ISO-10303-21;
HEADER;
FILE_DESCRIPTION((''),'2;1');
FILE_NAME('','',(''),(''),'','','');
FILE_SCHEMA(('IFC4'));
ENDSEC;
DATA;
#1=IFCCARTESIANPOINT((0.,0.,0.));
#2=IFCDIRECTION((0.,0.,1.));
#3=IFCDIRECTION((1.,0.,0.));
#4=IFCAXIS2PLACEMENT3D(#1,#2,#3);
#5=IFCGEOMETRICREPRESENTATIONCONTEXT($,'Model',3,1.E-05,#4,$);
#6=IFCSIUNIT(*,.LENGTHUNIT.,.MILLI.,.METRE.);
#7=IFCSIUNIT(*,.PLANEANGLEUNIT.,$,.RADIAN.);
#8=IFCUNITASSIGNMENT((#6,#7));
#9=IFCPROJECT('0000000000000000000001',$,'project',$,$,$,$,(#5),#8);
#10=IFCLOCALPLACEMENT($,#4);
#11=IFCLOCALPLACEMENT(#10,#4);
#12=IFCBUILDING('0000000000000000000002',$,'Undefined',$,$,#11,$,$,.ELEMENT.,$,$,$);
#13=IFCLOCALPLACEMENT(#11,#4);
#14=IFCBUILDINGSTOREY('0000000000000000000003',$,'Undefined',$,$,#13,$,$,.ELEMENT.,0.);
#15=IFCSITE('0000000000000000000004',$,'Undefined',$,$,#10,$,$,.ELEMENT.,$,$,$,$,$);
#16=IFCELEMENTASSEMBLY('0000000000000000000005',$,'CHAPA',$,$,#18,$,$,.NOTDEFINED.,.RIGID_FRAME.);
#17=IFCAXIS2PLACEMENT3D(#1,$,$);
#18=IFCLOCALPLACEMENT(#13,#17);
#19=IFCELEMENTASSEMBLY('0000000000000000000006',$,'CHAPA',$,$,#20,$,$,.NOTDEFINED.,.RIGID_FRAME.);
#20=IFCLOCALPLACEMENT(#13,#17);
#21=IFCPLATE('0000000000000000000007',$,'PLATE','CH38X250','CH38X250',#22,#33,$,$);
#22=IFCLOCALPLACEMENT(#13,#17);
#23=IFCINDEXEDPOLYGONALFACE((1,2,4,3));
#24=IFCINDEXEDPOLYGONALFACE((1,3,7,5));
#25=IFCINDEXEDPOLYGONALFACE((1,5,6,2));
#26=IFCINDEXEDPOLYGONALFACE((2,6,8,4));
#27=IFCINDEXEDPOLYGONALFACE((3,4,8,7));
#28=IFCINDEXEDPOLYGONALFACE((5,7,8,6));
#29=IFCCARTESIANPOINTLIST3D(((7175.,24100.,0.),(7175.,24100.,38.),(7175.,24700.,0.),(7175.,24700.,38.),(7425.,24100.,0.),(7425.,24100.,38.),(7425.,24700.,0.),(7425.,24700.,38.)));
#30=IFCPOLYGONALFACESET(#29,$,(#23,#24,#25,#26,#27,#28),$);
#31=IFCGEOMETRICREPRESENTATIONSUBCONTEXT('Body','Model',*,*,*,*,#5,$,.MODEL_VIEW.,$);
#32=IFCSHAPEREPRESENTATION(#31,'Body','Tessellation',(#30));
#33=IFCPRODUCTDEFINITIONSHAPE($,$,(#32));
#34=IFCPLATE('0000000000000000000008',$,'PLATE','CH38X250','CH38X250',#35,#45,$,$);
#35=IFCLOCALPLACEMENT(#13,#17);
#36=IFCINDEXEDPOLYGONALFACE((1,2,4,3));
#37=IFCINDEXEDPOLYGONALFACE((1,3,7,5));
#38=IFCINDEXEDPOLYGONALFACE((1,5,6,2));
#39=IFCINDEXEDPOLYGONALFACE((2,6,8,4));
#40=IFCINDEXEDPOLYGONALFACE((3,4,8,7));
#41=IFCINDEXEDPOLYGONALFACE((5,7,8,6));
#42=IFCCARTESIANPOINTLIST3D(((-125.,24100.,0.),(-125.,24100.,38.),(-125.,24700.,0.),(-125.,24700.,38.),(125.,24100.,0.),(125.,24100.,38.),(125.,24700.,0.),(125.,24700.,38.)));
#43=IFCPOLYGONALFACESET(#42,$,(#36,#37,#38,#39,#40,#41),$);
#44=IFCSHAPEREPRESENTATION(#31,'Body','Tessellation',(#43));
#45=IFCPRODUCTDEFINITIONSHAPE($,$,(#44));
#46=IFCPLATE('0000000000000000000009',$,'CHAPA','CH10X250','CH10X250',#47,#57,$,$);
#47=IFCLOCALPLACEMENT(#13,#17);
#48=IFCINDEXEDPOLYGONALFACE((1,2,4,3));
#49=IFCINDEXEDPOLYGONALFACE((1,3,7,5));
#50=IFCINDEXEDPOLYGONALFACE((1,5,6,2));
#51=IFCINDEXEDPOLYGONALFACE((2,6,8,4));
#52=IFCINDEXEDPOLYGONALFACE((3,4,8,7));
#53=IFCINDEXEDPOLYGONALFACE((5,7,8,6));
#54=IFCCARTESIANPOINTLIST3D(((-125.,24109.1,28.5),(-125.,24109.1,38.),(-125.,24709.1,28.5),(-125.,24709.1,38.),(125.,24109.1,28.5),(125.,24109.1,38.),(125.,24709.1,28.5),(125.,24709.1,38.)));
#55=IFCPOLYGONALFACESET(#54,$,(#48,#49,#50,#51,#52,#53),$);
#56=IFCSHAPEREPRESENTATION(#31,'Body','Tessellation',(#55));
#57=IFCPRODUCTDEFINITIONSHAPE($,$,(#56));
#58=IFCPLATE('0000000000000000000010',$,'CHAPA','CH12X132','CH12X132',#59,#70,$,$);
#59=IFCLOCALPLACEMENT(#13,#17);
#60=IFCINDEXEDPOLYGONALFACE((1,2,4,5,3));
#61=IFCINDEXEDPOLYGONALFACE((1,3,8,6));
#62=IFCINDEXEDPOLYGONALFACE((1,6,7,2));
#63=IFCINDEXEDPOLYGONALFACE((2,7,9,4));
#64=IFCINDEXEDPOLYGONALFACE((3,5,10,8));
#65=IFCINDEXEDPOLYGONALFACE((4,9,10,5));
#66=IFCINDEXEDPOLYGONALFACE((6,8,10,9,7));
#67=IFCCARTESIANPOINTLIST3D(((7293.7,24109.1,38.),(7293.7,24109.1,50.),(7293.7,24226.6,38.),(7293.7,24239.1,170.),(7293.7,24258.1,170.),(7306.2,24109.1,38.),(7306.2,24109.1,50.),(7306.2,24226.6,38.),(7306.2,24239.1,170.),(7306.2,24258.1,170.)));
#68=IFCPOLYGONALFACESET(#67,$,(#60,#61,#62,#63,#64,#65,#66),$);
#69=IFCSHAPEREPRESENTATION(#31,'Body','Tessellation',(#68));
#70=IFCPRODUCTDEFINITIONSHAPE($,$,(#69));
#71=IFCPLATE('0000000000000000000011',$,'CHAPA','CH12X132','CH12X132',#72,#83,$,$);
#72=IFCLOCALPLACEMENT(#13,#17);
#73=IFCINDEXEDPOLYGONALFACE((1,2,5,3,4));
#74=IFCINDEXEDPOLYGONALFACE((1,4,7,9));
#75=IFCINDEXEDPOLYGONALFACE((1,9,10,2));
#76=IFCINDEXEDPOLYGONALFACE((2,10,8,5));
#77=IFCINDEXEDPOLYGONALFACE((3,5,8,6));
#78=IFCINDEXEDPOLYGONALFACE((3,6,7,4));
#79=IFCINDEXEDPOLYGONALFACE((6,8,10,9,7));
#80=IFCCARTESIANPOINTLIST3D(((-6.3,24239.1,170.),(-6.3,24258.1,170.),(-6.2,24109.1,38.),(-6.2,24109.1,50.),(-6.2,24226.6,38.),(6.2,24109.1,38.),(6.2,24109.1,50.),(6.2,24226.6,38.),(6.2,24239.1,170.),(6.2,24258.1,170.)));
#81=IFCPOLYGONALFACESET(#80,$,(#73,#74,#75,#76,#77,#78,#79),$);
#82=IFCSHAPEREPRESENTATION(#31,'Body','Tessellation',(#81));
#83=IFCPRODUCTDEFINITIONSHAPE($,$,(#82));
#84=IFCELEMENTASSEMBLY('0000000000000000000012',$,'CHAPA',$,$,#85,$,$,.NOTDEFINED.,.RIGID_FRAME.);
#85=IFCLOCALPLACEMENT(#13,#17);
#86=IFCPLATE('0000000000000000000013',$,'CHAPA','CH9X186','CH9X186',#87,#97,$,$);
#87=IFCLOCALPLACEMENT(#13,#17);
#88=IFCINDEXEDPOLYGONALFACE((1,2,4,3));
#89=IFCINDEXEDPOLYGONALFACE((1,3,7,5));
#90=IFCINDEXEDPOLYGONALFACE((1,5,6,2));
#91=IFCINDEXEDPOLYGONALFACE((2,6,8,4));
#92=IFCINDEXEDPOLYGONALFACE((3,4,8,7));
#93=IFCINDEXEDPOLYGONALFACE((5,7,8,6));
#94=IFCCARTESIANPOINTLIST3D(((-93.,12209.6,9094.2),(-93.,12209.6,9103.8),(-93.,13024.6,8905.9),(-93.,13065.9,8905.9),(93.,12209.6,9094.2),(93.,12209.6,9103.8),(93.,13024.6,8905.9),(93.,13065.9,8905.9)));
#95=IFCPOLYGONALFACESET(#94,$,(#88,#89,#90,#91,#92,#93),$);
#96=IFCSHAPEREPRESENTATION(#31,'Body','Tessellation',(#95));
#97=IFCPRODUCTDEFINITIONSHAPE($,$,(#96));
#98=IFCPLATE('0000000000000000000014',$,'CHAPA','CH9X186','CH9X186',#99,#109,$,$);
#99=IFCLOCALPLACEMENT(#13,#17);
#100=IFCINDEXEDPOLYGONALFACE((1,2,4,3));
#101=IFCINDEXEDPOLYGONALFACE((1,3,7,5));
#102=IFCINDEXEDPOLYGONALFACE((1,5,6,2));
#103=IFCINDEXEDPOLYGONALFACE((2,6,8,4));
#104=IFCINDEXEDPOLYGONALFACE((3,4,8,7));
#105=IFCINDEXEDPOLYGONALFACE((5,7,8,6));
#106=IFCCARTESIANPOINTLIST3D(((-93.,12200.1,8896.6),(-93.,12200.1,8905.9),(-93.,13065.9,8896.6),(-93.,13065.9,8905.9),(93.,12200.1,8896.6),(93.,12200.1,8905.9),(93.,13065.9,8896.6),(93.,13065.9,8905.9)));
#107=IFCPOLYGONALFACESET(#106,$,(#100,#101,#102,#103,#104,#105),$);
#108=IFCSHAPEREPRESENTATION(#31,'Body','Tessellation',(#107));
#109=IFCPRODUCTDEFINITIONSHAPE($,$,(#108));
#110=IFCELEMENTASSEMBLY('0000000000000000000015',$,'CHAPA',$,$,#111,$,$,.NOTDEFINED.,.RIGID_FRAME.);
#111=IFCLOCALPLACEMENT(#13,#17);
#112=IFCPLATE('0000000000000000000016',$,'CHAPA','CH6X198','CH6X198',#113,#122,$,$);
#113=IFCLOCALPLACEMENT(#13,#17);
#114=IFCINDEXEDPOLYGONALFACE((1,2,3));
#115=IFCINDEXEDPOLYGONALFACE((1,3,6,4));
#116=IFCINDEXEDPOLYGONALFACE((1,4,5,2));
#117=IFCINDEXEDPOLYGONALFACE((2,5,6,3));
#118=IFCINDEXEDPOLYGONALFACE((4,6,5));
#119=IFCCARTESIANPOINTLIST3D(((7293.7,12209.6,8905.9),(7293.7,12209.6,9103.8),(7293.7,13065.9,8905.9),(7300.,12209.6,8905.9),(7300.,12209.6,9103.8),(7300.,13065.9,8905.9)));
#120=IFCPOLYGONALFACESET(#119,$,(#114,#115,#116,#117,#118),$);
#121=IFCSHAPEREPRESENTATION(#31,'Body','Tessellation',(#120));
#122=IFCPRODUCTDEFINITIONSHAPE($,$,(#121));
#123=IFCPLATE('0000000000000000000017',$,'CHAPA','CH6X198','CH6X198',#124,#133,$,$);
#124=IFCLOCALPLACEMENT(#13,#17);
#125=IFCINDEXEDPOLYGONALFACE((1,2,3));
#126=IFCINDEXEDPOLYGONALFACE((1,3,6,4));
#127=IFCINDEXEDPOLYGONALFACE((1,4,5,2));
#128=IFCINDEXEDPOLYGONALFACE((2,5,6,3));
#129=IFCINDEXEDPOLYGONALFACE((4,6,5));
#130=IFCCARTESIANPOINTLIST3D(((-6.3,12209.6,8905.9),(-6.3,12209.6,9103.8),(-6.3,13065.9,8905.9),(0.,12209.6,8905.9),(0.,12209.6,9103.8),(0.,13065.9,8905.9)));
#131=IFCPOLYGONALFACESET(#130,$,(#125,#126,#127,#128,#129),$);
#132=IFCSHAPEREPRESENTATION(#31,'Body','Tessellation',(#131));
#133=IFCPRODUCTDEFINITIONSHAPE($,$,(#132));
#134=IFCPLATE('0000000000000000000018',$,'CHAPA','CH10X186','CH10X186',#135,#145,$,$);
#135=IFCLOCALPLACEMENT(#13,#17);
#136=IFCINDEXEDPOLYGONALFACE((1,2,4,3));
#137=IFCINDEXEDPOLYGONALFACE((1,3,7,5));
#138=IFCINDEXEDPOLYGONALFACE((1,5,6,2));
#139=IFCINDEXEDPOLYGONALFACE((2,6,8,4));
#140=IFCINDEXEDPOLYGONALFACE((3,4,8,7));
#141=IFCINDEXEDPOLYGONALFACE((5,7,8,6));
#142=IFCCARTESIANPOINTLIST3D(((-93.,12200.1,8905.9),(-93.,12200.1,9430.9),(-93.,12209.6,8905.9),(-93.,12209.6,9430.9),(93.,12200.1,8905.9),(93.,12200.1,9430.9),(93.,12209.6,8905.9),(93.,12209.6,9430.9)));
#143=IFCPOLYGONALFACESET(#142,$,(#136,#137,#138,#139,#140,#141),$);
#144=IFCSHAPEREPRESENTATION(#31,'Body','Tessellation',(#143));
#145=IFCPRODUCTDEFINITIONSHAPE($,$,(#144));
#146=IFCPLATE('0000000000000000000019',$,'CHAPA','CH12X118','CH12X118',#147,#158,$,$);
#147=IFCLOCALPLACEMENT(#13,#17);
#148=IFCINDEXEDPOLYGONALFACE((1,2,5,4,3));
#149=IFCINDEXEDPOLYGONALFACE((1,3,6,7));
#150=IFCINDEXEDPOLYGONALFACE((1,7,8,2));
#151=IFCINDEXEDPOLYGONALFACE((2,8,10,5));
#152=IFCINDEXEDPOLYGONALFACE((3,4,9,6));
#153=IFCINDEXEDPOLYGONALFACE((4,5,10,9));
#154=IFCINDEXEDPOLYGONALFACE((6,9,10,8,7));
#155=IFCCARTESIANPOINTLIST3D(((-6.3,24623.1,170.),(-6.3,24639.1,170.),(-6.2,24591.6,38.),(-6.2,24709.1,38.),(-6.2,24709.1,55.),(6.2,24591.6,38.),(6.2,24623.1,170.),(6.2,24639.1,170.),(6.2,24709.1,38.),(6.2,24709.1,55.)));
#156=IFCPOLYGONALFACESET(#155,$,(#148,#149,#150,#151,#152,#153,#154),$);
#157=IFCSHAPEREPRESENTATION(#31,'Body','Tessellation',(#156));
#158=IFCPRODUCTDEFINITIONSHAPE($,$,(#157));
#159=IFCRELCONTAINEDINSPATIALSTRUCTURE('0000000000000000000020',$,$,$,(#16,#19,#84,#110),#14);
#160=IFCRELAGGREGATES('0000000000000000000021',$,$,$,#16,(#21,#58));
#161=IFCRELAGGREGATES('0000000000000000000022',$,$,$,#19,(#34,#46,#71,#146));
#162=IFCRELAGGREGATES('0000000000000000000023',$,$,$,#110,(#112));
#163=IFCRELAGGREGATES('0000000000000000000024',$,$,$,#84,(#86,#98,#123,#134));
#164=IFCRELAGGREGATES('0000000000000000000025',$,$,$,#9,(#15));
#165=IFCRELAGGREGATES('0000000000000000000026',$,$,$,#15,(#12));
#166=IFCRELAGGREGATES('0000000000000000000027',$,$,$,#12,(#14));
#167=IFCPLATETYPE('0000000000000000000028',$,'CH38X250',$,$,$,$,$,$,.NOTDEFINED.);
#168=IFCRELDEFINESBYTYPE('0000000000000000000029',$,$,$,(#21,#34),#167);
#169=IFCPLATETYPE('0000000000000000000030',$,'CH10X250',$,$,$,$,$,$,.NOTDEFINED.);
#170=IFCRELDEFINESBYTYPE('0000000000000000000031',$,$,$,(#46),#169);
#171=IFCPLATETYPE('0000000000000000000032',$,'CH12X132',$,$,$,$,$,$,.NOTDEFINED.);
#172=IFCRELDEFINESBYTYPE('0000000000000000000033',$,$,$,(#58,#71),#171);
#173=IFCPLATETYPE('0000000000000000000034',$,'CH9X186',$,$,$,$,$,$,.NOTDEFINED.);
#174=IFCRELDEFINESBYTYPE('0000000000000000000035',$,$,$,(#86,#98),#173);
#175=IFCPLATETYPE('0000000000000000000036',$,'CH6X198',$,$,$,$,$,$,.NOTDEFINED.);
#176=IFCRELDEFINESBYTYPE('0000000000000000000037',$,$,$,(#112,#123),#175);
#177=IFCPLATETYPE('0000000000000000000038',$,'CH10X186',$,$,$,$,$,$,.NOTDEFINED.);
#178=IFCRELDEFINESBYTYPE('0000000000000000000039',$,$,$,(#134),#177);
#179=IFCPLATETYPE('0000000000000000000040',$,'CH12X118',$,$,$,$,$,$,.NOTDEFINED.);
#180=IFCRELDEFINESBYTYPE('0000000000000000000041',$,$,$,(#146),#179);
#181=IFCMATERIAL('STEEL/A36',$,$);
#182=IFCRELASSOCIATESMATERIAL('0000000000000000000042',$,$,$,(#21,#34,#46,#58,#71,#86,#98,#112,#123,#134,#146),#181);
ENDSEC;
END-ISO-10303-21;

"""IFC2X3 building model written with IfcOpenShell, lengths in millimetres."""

from ifc_helpers import new_model, si_unit, frame, origin_with_axes, place, context, subcontext, project, spatial, polyline, outline, extrude, clip, halfspace, material, type_object, element, aggregate, save


model = new_model("IFC2X3")

# Units and contexts
model_context = context("Model", 3, precision=1e-05, world=origin_with_axes())
body_context = subcontext(model_context, "Body", "Model", "MODEL_VIEW")
ifc_project = project(units=[si_unit("LENGTHUNIT", "METRE", prefix="MILLI"), si_unit("PLANEANGLEUNIT", "RADIAN")], contexts=[model_context])

# Site, building, storey
site_placement = place(None, origin_with_axes())
site = spatial("IfcSite", under=ifc_project, at=site_placement, Name="Undefined", CompositionType="ELEMENT")
building_placement = place(site_placement, origin_with_axes())
building = spatial("IfcBuilding", under=site, at=building_placement, Name="Undefined", CompositionType="ELEMENT")
storey_placement = place(building_placement, origin_with_axes())
storey = spatial("IfcBuildingStorey", under=building, at=storey_placement, Name="Undefined", CompositionType="ELEMENT", Elevation=0.0)

# Element assemblies
assembly_1_placement = place(storey_placement, origin_with_axes())
assembly_1 = element("IfcElementAssembly", 1, at=assembly_1_placement, inside=storey, Name="CHAPA", AssemblyPlace="NOTDEFINED", PredefinedType="RIGID_FRAME")
assembly_2_placement = place(storey_placement, origin_with_axes())
assembly_2 = element("IfcElementAssembly", 2, at=assembly_2_placement, inside=storey, Name="CHAPA", AssemblyPlace="NOTDEFINED", PredefinedType="RIGID_FRAME")

# Plates
ifc_material_1 = material(Name="STEEL/A36")
plate_type_1 = type_object("IfcPlateType", Name="CH38X250", PredefinedType="NOTDEFINED")
plate_1_placement = place(assembly_1_placement, frame((7175.0, 24700.0, 19.0), z_axis=(0.0, 0.0, 1.0), x_axis=(0.0, -1.0, 0.0)))
plate_1 = element("IfcPlate", 3, at=plate_1_placement, type_object=plate_type_1, material=ifc_material_1, Name="PLATE", Description="CH38X250", ObjectType="CH38X250", context=body_context, shape_type="SweptSolid", body=[
    extrude(outline(polyline([(0.0, 0.0), (600.0, 0.0), (600.0, 250.0), (0.0, 250.0), (0.0, 0.0)])), frame((0.0, 0.0, -19.0), z_axis=(0.0, 0.0, 1.0), x_axis=(1.0, 0.0, 0.0)), (0.0, 0.0, 1.0), 38.0),
])
plate_2_placement = place(assembly_2_placement, frame((-125.0, 24700.0, 19.0), z_axis=(0.0, 0.0, 1.0), x_axis=(0.0, -1.0, 0.0)))
plate_2 = element("IfcPlate", 4, at=plate_2_placement, type_object=plate_type_1, material=ifc_material_1, Name="PLATE", Description="CH38X250", ObjectType="CH38X250", context=body_context, shape_type="SweptSolid", body=[
    extrude(outline(polyline([(0.0, 0.0), (600.0, 0.0), (600.0, 250.0), (0.0, 250.0), (0.0, 0.0)])), frame((0.0, 0.0, -19.0), z_axis=(0.0, 0.0, 1.0), x_axis=(1.0, 0.0, 0.0)), (0.0, 0.0, 1.0), 38.0),
])
plate_type_2 = type_object("IfcPlateType", Name="CH10X250", PredefinedType="NOTDEFINED")
plate_3_placement = place(assembly_2_placement, frame((-125.0, 24709.1, 33.2), z_axis=(0.0, 0.0, -1.0), x_axis=(1.0, 0.0, 0.0)))
plate_3 = element("IfcPlate", 5, at=plate_3_placement, type_object=plate_type_2, material=ifc_material_1, Name="CHAPA", Description="CH10X250", ObjectType="CH10X250", context=body_context, shape_type="SweptSolid", body=[
    extrude(outline(polyline([(0.0, 0.0), (250.0, 0.0), (250.0, 600.0), (0.0, 600.0), (0.0, 0.0)])), frame((0.0, 0.0, -4.8), z_axis=(0.0, 0.0, 1.0), x_axis=(1.0, 0.0, 0.0)), (0.0, 0.0, 1.0), 9.5),
])
plate_type_3 = type_object("IfcPlateType", Name="CH12X132", PredefinedType="NOTDEFINED")
plate_4_placement = place(assembly_1_placement, frame((7300.0, 24226.6, 38.0), z_axis=(-1.0, 0.0, 0.0), x_axis=(0.0, -1.0, 0.0)))
plate_4 = element("IfcPlate", 6, at=plate_4_placement, type_object=plate_type_3, material=ifc_material_1, Name="CHAPA", Description="CH12X132", ObjectType="CH12X132", context=body_context, shape_type="SweptSolid", body=[
    extrude(outline(polyline([(0.0, 0.0), (117.5, 0.0), (117.5, 12.0), (-12.5, 132.0), (-31.6, 132.0), (0.0, 0.0)])), frame((0.0, 0.0, -6.2), z_axis=(0.0, 0.0, 1.0), x_axis=(1.0, 0.0, 0.0)), (0.0, 0.0, 1.0), 12.5),
])
plate_5_placement = place(assembly_2_placement, frame((0.0, 24226.6, 38.0), z_axis=(-1.0, 0.0, 0.0), x_axis=(0.0, -1.0, 0.0)))
plate_5 = element("IfcPlate", 7, at=plate_5_placement, type_object=plate_type_3, material=ifc_material_1, Name="CHAPA", Description="CH12X132", ObjectType="CH12X132", context=body_context, shape_type="SweptSolid", body=[
    extrude(outline(polyline([(0.0, 0.0), (117.5, 0.0), (117.5, 12.0), (-12.5, 132.0), (-31.6, 132.0), (0.0, 0.0)])), frame((0.0, 0.0, -6.2), z_axis=(0.0, 0.0, 1.0), x_axis=(1.0, 0.0, 0.0)), (0.0, 0.0, 1.0), 12.5),
])

# Element assembly, plates
assembly_3_placement = place(storey_placement, origin_with_axes())
assembly_3 = element("IfcElementAssembly", 8, at=assembly_3_placement, inside=storey, Name="CHAPA", AssemblyPlace="NOTDEFINED", PredefinedType="RIGID_FRAME")
plate_type_4 = type_object("IfcPlateType", Name="CH9X186", PredefinedType="NOTDEFINED")
plate_6_placement = place(assembly_3_placement, frame((93.0, 12208.6, 9099.3), z_axis=(0.0, -0.225125, -0.97433), x_axis=(-1.0, 0.0, 0.0)))
plate_6 = element("IfcPlate", 9, at=plate_6_placement, type_object=plate_type_4, material=ifc_material_1, Name="CHAPA", Description="CH9X186", ObjectType="CH9X186", context=body_context, shape_type="Clipping", body=[
    clip(clip(extrude(outline(polyline([(0.0, 0.0), (186.0, 0.0), (186.0, 878.9), (0.0, 878.9), (0.0, 0.0)])), frame((0.0, 0.0, -4.7), z_axis=(0.0, 0.0, 1.0), x_axis=(1.0, 0.0, 0.0)), (0.0, 0.0, 1.0), 9.3), halfspace(frame((186.0, -500.0, 314.0), z_axis=(0.0, 0.225128, 0.974329), x_axis=(-1.0, 0.0, 0.0)), False)), halfspace(frame((0.0, 2.1, 4.7), z_axis=(0.0, -0.97433, 0.225125), x_axis=(1.0, 0.0, 0.0)), False)),
])
plate_7_placement = place(assembly_3_placement, frame((93.0, 12200.1, 8901.3), z_axis=(0.0, 0.0, -1.0), x_axis=(-1.0, 0.0, 0.0)))
plate_7 = element("IfcPlate", 10, at=plate_7_placement, type_object=plate_type_4, material=ifc_material_1, Name="CHAPA", Description="CH9X186", ObjectType="CH9X186", context=body_context, shape_type="SweptSolid", body=[
    extrude(outline(polyline([(0.0, 0.0), (186.0, 0.0), (186.0, 865.8), (0.0, 865.8), (0.0, 0.0)])), frame((0.0, 0.0, -4.7), z_axis=(0.0, 0.0, 1.0), x_axis=(1.0, 0.0, 0.0)), (0.0, 0.0, 1.0), 9.3),
])

# Element assembly, plate
assembly_4_placement = place(storey_placement, origin_with_axes())
assembly_4 = element("IfcElementAssembly", 11, at=assembly_4_placement, inside=storey, Name="CHAPA", AssemblyPlace="NOTDEFINED", PredefinedType="RIGID_FRAME")
plate_type_5 = type_object("IfcPlateType", Name="CH6X198", PredefinedType="NOTDEFINED")
plate_8_placement = place(assembly_4_placement, frame((7296.9, 13065.9, 8905.9), z_axis=(-1.0, 0.0, 0.0), x_axis=(0.0, -1.0, 0.0)))
plate_8 = element("IfcPlate", 12, at=plate_8_placement, type_object=plate_type_5, material=ifc_material_1, Name="CHAPA", Description="CH6X198", ObjectType="CH6X198", context=body_context, shape_type="SweptSolid", body=[
    extrude(outline(polyline([(0.0, 0.0), (856.3, 0.0), (856.3, 197.9), (0.0, 0.0)])), frame((0.0, 0.0, -3.1), z_axis=(0.0, 0.0, 1.0), x_axis=(1.0, 0.0, 0.0)), (0.0, 0.0, 1.0), 6.3),
])

# Plates
plate_9_placement = place(assembly_3_placement, frame((-3.1, 13065.9, 8905.9), z_axis=(-1.0, 0.0, 0.0), x_axis=(0.0, -1.0, 0.0)))
plate_9 = element("IfcPlate", 13, at=plate_9_placement, type_object=plate_type_5, material=ifc_material_1, Name="CHAPA", Description="CH6X198", ObjectType="CH6X198", context=body_context, shape_type="SweptSolid", body=[
    extrude(outline(polyline([(0.0, 0.0), (856.3, 0.0), (856.3, 197.9), (0.0, 0.0)])), frame((0.0, 0.0, -3.1), z_axis=(0.0, 0.0, 1.0), x_axis=(1.0, 0.0, 0.0)), (0.0, 0.0, 1.0), 6.3),
])
plate_type_6 = type_object("IfcPlateType", Name="CH10X186", PredefinedType="NOTDEFINED")
plate_10_placement = place(assembly_3_placement, frame((93.0, 12204.8, 9430.9), z_axis=(0.0, -1.0, 0.0), x_axis=(-1.0, 0.0, 0.0)))
plate_10 = element("IfcPlate", 14, at=plate_10_placement, type_object=plate_type_6, material=ifc_material_1, Name="CHAPA", Description="CH10X186", ObjectType="CH10X186", context=body_context, shape_type="SweptSolid", body=[
    extrude(outline(polyline([(0.0, 0.0), (186.0, 0.0), (186.0, 525.0), (0.0, 525.0), (0.0, 0.0)])), frame((0.0, 0.0, -4.8), z_axis=(0.0, 0.0, 1.0), x_axis=(1.0, 0.0, 0.0)), (0.0, 0.0, 1.0), 9.5),
])
plate_type_7 = type_object("IfcPlateType", Name="CH12X118", PredefinedType="NOTDEFINED")
plate_11_placement = place(assembly_2_placement, frame((0.0, 24709.1, 38.0), z_axis=(-1.0, 0.0, 0.0), x_axis=(0.0, -1.0, 0.0)))
plate_11 = element("IfcPlate", 15, at=plate_11_placement, type_object=plate_type_7, material=ifc_material_1, Name="CHAPA", Description="CH12X118", ObjectType="CH12X118", context=body_context, shape_type="SweptSolid", body=[
    extrude(outline(polyline([(0.0, 0.0), (117.5, 0.0), (85.9, 132.0), (70.0, 132.0), (0.0, 17.0), (0.0, 0.0)])), frame((0.0, 0.0, -6.2), z_axis=(0.0, 0.0, 1.0), x_axis=(1.0, 0.0, 0.0)), (0.0, 0.0, 1.0), 12.5),
])

aggregate(assembly_1, [plate_1, plate_4])
aggregate(assembly_2, [plate_2, plate_3, plate_5, plate_11])
aggregate(assembly_4, [plate_8])
aggregate(assembly_3, [plate_6, plate_7, plate_9, plate_10])

save(model, "model.ifc")
